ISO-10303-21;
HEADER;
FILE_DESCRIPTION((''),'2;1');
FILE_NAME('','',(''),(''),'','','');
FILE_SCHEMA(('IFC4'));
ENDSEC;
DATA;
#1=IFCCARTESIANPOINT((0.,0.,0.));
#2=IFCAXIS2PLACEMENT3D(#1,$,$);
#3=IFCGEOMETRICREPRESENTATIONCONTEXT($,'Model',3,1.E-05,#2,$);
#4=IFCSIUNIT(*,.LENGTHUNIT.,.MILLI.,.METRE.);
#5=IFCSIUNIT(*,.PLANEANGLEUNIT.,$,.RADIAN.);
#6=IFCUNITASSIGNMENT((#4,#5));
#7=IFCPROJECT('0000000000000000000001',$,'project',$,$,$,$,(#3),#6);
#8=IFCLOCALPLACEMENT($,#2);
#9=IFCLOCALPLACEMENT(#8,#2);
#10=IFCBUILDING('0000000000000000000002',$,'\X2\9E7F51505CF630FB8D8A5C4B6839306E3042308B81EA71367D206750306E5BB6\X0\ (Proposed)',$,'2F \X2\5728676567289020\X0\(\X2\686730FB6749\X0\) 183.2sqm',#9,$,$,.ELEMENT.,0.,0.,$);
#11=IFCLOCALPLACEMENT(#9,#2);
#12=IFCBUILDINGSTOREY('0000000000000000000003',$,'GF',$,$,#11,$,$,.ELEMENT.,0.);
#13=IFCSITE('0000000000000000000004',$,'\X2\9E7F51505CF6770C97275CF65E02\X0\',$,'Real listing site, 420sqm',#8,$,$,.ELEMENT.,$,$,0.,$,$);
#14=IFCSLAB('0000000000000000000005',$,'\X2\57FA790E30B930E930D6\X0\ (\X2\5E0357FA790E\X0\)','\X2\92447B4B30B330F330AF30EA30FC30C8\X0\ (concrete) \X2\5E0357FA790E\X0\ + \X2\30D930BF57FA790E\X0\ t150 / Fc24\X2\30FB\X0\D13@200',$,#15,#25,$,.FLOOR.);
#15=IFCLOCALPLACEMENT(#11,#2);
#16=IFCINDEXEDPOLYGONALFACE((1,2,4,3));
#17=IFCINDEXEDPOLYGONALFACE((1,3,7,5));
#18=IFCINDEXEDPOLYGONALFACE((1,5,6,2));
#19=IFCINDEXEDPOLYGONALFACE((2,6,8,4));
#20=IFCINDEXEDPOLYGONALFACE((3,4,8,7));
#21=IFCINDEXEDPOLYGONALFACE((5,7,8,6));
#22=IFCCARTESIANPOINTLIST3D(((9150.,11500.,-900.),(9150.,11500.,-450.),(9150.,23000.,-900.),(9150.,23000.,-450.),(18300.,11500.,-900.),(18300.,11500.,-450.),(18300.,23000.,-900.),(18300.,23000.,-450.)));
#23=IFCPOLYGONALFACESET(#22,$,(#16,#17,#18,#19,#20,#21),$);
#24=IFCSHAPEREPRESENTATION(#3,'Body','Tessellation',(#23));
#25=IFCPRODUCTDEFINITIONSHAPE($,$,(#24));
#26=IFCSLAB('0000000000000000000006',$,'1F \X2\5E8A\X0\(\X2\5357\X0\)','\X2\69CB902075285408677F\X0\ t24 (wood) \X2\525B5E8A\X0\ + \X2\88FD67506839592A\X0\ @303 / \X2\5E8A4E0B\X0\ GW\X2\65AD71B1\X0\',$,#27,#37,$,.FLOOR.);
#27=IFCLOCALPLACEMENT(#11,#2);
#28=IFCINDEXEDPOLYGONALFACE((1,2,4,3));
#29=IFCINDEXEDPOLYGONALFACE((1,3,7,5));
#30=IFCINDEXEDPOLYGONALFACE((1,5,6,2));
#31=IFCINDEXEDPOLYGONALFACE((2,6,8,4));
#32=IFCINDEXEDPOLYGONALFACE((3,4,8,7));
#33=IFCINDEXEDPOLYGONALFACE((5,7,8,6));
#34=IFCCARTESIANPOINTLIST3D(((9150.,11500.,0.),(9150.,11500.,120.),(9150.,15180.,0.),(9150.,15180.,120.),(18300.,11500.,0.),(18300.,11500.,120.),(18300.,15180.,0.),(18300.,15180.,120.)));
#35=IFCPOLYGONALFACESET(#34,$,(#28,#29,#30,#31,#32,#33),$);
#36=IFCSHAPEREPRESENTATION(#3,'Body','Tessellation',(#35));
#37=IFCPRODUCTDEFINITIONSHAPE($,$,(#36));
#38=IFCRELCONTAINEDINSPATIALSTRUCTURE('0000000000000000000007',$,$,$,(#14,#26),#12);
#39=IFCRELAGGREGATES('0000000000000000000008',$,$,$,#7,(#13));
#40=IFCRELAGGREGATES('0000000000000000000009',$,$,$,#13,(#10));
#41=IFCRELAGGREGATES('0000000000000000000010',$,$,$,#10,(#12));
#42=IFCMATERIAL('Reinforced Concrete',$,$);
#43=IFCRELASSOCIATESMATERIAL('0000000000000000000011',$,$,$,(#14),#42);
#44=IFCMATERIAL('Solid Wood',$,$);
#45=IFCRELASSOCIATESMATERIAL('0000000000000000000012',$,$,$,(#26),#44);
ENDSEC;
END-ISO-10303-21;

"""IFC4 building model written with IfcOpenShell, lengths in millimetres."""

from ifc_helpers import new_model, si_unit, frame, frame_2d, origin, place, context, project, spatial, rectangle, extrude, material, element, save


model = new_model("IFC4")

# Units and contexts
model_context = context("Model", 3, precision=1e-05, world=origin())
ifc_project = project(units=[si_unit("LENGTHUNIT", "METRE", prefix="MILLI"), si_unit("PLANEANGLEUNIT", "RADIAN")], contexts=[model_context])

# Site, building, storey
site_placement = place(None, origin())
site = spatial("IfcSite", under=ifc_project, at=site_placement, Name="鹿児島県霧島市", ObjectType="Real listing site, 420sqm", CompositionType="ELEMENT", RefElevation=0.0)
building_placement = place(site_placement, origin())
building = spatial("IfcBuilding", under=site, at=building_placement, Name="鹿児島・越屋根のある自然素材の家 (Proposed)", ObjectType="2F 在来木造(桧・杉) 183.2sqm", CompositionType="ELEMENT", ElevationOfRefHeight=0.0, ElevationOfTerrain=0.0)
storey_placement = place(building_placement, origin())
storey = spatial("IfcBuildingStorey", under=building, at=storey_placement, Name="GF", CompositionType="ELEMENT", Elevation=0.0)

# Shared definitions
ifc_material_1 = material(Name="Solid Wood")

# Slabs
ifc_material_2 = material(Name="Reinforced Concrete")
slab_1_placement = place(storey_placement, frame((4575.0, 5750.0, -450.0)))
element("IfcSlab", 1, at=slab_1_placement, inside=storey, material=ifc_material_2, Name="基礎スラブ (布基礎)", Description="鉄筋コンクリート (concrete) 布基礎 + ベタ基礎 t150 / Fc24・D13@200", PredefinedType="FLOOR", context=model_context, shape_type="SweptSolid", body=[
    extrude(rectangle(XDim=9150.0, YDim=11500.0, at=frame_2d((4575.0, 5750.0))), frame((4575.0, 5750.0, -450.0)), (0.0, 0.0, 1.0), 450.0),
])
slab_2_placement = place(storey_placement, frame((4575.0, 5750.0, 0.0)))
element("IfcSlab", 2, at=slab_2_placement, inside=storey, material=ifc_material_1, Name="1F 床(南)", Description="構造用合板 t24 (wood) 剛床 + 製材根太 @303 / 床下 GW断熱", PredefinedType="FLOOR", context=model_context, shape_type="SweptSolid", body=[
    extrude(rectangle(XDim=9150.0, YDim=3680.0, at=frame_2d((4575.0, 1840.0))), frame((4575.0, 5750.0, 0.0)), (0.0, 0.0, 1.0), 120.0),
])

save(model, "model.ifc")
